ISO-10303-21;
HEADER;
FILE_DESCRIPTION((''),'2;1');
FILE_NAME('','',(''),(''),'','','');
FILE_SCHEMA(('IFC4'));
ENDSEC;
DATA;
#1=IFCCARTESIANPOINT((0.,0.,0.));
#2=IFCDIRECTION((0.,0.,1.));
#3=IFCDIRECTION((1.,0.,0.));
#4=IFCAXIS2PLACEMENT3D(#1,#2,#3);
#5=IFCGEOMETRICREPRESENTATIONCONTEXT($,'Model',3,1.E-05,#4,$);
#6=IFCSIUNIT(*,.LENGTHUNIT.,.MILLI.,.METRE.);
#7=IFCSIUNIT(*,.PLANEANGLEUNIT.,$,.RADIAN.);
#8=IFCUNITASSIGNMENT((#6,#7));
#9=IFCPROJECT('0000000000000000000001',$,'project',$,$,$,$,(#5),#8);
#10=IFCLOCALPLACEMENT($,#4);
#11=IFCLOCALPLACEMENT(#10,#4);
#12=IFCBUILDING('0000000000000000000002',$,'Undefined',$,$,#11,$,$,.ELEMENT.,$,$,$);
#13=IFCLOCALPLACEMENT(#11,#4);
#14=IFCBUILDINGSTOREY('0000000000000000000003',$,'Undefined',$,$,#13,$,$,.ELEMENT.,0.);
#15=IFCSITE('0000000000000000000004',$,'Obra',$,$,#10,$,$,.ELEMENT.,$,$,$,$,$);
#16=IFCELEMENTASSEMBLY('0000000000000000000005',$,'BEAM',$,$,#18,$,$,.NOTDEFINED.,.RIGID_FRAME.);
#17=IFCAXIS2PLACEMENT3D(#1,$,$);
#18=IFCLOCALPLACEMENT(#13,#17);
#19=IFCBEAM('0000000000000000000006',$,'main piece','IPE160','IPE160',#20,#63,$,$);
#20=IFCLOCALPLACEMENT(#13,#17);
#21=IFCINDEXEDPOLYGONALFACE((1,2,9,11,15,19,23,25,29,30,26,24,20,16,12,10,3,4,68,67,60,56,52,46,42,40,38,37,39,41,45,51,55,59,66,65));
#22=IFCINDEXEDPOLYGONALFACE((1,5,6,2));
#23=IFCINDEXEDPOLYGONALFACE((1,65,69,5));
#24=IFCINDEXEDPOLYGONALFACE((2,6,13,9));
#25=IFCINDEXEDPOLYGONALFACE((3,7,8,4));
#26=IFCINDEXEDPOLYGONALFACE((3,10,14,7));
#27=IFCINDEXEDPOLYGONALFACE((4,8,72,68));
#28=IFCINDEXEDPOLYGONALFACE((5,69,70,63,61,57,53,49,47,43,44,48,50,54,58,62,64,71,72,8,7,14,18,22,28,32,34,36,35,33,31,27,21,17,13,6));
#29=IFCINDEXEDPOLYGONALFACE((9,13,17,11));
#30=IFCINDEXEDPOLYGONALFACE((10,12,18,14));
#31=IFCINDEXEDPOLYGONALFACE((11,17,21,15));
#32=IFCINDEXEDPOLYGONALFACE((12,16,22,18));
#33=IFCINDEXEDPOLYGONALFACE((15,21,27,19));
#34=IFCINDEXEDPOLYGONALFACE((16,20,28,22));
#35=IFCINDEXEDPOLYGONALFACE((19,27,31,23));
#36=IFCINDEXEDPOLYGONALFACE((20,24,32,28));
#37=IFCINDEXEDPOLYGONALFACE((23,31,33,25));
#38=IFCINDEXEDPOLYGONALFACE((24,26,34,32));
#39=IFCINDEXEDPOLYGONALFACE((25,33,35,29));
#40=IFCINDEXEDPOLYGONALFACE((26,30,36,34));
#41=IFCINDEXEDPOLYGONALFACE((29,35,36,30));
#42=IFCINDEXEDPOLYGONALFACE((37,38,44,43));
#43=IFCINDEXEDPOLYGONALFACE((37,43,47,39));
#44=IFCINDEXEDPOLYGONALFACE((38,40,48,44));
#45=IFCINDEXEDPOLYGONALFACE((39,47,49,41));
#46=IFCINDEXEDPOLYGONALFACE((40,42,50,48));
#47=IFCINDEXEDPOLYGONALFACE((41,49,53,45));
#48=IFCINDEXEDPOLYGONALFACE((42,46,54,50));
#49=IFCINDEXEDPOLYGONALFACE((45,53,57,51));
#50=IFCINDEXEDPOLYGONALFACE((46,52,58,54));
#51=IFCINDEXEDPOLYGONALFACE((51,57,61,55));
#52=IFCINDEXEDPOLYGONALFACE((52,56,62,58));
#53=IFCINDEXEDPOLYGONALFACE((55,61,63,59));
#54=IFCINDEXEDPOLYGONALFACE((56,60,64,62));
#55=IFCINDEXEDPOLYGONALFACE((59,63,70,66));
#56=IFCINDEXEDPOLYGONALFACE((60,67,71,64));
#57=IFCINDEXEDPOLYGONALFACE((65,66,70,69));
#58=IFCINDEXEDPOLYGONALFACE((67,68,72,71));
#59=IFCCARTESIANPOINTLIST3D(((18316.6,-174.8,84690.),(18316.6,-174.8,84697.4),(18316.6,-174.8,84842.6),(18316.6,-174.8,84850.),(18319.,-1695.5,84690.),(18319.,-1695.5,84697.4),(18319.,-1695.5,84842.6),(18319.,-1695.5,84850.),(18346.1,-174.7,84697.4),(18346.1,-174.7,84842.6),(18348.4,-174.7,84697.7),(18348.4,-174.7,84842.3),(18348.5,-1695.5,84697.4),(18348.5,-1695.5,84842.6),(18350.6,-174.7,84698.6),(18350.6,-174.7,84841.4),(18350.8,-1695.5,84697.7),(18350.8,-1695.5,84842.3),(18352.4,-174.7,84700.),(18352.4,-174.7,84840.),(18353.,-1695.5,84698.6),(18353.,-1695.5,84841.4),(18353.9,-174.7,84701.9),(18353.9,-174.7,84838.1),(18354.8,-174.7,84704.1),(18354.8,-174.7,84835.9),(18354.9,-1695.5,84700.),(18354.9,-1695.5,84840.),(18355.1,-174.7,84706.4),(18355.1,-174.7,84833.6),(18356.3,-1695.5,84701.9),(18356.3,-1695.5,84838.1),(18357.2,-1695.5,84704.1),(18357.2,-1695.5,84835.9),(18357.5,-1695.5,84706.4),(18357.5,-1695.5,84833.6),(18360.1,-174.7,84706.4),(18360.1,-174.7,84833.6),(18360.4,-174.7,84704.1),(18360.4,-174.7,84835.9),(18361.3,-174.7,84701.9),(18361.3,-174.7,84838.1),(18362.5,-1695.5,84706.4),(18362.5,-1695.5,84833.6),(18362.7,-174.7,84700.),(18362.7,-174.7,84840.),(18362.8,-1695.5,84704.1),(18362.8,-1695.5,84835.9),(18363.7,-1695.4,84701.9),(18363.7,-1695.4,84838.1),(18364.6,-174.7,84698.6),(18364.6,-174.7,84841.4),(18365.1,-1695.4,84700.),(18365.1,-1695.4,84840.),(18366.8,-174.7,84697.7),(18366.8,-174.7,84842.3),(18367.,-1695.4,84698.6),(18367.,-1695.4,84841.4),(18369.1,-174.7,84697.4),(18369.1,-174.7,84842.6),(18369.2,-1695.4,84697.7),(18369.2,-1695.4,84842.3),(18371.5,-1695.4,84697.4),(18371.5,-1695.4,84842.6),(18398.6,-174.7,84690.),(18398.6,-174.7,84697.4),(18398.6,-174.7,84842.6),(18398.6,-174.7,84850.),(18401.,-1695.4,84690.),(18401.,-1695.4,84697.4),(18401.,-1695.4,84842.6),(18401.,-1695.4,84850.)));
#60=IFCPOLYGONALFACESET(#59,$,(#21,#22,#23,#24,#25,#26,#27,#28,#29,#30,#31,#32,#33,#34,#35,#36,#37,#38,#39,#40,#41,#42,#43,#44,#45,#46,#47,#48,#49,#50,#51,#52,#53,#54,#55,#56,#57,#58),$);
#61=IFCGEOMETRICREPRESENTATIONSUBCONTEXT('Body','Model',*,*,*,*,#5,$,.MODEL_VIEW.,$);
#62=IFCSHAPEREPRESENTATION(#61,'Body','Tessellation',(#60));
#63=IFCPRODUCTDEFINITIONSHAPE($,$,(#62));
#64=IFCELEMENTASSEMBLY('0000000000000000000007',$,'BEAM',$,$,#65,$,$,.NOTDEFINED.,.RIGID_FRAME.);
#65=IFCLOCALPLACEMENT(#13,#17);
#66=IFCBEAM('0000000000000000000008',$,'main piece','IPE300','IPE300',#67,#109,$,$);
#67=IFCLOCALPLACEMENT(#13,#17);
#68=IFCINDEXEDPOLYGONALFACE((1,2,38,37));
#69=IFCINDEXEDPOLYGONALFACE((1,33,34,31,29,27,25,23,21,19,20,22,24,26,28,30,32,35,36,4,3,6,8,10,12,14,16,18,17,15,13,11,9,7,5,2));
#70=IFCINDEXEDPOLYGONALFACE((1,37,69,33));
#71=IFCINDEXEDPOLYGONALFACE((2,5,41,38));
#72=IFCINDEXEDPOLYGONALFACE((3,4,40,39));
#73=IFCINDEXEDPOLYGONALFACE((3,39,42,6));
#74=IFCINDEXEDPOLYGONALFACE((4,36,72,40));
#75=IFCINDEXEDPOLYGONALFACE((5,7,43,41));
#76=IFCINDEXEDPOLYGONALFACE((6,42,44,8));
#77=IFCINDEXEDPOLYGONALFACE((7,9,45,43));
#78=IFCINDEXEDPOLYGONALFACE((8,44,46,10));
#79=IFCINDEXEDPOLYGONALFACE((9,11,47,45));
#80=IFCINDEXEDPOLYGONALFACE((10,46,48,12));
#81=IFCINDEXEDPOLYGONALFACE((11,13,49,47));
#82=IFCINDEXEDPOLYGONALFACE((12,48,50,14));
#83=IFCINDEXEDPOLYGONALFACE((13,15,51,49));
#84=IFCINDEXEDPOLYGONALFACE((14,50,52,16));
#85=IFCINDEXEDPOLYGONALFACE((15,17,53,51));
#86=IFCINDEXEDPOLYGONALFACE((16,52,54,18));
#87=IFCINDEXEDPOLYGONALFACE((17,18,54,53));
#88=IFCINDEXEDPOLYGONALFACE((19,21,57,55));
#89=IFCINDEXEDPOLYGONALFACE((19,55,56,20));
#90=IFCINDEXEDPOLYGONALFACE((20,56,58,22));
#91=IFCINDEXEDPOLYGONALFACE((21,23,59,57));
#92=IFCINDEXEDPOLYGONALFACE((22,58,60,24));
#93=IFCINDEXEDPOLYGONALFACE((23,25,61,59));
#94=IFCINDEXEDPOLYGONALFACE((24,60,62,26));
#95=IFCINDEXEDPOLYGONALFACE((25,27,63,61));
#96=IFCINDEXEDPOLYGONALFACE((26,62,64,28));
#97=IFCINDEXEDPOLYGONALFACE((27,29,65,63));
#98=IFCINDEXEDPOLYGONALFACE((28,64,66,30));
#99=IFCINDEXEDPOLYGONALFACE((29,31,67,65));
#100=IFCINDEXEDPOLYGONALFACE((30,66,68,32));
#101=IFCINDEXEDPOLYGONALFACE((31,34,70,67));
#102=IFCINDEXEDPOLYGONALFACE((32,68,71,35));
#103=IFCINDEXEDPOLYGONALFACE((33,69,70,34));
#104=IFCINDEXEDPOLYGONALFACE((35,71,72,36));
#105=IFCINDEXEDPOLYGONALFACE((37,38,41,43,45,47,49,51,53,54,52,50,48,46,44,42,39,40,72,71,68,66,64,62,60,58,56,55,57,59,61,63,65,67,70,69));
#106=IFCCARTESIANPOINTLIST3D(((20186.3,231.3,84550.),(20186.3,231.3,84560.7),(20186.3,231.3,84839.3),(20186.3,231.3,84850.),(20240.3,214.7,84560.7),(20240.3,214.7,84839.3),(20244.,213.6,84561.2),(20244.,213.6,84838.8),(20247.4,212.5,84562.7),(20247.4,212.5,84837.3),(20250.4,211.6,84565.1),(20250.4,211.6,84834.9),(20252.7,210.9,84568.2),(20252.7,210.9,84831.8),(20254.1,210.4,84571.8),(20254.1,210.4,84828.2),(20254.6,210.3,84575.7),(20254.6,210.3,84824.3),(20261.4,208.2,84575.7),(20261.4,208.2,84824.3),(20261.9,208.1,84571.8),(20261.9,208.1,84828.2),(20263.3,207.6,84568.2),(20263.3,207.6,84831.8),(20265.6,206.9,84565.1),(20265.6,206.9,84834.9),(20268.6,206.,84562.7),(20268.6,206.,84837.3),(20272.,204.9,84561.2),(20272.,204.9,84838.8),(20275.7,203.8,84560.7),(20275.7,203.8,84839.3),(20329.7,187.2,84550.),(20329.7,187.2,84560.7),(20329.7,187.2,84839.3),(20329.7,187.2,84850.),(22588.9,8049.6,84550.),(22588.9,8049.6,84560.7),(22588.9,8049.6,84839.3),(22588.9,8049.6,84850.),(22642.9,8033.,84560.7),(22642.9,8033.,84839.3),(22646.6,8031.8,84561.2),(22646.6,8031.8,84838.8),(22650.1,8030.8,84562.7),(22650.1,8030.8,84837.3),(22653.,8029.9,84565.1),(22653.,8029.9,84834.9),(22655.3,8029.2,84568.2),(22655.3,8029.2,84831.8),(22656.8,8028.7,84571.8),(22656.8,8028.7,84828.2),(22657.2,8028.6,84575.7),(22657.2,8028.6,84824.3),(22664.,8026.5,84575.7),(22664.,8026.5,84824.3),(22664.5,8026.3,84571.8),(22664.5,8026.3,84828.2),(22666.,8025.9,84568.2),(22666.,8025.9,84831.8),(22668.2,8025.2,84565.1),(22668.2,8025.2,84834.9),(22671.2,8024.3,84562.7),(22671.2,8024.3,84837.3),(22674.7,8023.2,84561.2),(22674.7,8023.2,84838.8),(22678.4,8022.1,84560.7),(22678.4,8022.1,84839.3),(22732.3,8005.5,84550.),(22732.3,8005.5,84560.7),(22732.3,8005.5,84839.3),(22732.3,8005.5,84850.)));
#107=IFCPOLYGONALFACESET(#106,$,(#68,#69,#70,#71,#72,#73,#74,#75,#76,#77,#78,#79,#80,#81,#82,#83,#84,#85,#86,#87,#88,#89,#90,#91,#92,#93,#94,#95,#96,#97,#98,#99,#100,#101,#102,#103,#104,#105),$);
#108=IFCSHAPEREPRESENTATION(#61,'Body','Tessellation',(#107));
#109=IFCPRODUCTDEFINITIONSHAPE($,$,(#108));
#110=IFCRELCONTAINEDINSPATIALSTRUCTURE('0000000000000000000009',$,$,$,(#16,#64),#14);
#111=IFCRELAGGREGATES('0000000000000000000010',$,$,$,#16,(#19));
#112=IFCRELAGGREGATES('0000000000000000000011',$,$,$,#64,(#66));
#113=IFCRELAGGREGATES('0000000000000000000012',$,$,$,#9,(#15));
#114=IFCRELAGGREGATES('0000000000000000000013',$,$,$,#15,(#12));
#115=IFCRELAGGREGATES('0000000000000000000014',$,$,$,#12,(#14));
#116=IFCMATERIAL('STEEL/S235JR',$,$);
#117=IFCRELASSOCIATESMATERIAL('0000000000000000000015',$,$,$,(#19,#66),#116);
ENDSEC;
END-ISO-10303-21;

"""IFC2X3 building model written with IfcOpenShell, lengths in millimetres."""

from ifc_helpers import new_model, si_unit, frame, origin_with_axes, origin_2d_with_axis, place, context, subcontext, project, spatial, i_section, extrude, material, element, aggregate, save


model = new_model("IFC2X3")

# Units and contexts
model_context = context("Model", 3, precision=1e-05, world=origin_with_axes())
body_context = subcontext(model_context, "Body", "Model", "MODEL_VIEW")
ifc_project = project(units=[si_unit("LENGTHUNIT", "METRE", prefix="MILLI"), si_unit("PLANEANGLEUNIT", "RADIAN")], contexts=[model_context])

# Site, building, storey
site_placement = place(None, origin_with_axes())
site = spatial("IfcSite", under=ifc_project, at=site_placement, Name="Obra", CompositionType="ELEMENT")
building_placement = place(site_placement, origin_with_axes())
building = spatial("IfcBuilding", under=site, at=building_placement, Name="Undefined", CompositionType="ELEMENT")
storey_placement = place(building_placement, origin_with_axes())
storey = spatial("IfcBuildingStorey", under=building, at=storey_placement, Name="Undefined", CompositionType="ELEMENT", Elevation=0.0)

# Element assemblies, beams
assembly_1_placement = place(storey_placement, origin_with_axes())
assembly_1 = element("IfcElementAssembly", 1, at=assembly_1_placement, inside=storey, Name="BEAM", AssemblyPlace="NOTDEFINED", PredefinedType="RIGID_FRAME")
ifc_material = material(Name="STEEL/S235JR")
beam_1_placement = place(assembly_1_placement, frame((18360.0, -1695.5, 84770.0), z_axis=(0.0, 0.0, 1.0), x_axis=(-0.001588, 0.999999, 0.0)))
beam_1 = element("IfcBeam", 2, at=beam_1_placement, material=ifc_material, Name="main piece", Description="IPE160", ObjectType="IPE160", context=body_context, shape_type="SweptSolid", body=[
    extrude(i_section(OverallWidth=82.0, OverallDepth=160.0, WebThickness=5.0, FlangeThickness=7.4, FilletRadius=9.0, at=origin_2d_with_axis()), frame((1520.7, 0.0, 0.0), z_axis=(-1.0, 0.0, 0.0), x_axis=(0.0, -1.0, 0.0)), (0.0, 0.0, 1.0), 1520.7),
])
aggregate(assembly_1, [beam_1])
assembly_2_placement = place(storey_placement, origin_with_axes())
assembly_2 = element("IfcElementAssembly", 3, at=assembly_2_placement, inside=storey, Name="BEAM", AssemblyPlace="NOTDEFINED", PredefinedType="RIGID_FRAME")
beam_2_placement = place(assembly_2_placement, frame((20258.0, 209.2, 84700.0), z_axis=(0.0, 0.0, 1.0), x_axis=(0.293752, 0.955882, 0.0)))
beam_2 = element("IfcBeam", 4, at=beam_2_placement, material=ifc_material, Name="main piece", Description="IPE300", ObjectType="IPE300", context=body_context, shape_type="SweptSolid", body=[
    extrude(i_section(OverallWidth=150.0, OverallDepth=300.0, WebThickness=7.1, FlangeThickness=10.7, FilletRadius=15.0, at=origin_2d_with_axis()), frame((8179.1, 0.0, 0.0), z_axis=(-1.0, 0.0, 0.0), x_axis=(0.0, -1.0, 0.0)), (0.0, 0.0, 1.0), 8179.1),
])
aggregate(assembly_2, [beam_2])

save(model, "model.ifc")
